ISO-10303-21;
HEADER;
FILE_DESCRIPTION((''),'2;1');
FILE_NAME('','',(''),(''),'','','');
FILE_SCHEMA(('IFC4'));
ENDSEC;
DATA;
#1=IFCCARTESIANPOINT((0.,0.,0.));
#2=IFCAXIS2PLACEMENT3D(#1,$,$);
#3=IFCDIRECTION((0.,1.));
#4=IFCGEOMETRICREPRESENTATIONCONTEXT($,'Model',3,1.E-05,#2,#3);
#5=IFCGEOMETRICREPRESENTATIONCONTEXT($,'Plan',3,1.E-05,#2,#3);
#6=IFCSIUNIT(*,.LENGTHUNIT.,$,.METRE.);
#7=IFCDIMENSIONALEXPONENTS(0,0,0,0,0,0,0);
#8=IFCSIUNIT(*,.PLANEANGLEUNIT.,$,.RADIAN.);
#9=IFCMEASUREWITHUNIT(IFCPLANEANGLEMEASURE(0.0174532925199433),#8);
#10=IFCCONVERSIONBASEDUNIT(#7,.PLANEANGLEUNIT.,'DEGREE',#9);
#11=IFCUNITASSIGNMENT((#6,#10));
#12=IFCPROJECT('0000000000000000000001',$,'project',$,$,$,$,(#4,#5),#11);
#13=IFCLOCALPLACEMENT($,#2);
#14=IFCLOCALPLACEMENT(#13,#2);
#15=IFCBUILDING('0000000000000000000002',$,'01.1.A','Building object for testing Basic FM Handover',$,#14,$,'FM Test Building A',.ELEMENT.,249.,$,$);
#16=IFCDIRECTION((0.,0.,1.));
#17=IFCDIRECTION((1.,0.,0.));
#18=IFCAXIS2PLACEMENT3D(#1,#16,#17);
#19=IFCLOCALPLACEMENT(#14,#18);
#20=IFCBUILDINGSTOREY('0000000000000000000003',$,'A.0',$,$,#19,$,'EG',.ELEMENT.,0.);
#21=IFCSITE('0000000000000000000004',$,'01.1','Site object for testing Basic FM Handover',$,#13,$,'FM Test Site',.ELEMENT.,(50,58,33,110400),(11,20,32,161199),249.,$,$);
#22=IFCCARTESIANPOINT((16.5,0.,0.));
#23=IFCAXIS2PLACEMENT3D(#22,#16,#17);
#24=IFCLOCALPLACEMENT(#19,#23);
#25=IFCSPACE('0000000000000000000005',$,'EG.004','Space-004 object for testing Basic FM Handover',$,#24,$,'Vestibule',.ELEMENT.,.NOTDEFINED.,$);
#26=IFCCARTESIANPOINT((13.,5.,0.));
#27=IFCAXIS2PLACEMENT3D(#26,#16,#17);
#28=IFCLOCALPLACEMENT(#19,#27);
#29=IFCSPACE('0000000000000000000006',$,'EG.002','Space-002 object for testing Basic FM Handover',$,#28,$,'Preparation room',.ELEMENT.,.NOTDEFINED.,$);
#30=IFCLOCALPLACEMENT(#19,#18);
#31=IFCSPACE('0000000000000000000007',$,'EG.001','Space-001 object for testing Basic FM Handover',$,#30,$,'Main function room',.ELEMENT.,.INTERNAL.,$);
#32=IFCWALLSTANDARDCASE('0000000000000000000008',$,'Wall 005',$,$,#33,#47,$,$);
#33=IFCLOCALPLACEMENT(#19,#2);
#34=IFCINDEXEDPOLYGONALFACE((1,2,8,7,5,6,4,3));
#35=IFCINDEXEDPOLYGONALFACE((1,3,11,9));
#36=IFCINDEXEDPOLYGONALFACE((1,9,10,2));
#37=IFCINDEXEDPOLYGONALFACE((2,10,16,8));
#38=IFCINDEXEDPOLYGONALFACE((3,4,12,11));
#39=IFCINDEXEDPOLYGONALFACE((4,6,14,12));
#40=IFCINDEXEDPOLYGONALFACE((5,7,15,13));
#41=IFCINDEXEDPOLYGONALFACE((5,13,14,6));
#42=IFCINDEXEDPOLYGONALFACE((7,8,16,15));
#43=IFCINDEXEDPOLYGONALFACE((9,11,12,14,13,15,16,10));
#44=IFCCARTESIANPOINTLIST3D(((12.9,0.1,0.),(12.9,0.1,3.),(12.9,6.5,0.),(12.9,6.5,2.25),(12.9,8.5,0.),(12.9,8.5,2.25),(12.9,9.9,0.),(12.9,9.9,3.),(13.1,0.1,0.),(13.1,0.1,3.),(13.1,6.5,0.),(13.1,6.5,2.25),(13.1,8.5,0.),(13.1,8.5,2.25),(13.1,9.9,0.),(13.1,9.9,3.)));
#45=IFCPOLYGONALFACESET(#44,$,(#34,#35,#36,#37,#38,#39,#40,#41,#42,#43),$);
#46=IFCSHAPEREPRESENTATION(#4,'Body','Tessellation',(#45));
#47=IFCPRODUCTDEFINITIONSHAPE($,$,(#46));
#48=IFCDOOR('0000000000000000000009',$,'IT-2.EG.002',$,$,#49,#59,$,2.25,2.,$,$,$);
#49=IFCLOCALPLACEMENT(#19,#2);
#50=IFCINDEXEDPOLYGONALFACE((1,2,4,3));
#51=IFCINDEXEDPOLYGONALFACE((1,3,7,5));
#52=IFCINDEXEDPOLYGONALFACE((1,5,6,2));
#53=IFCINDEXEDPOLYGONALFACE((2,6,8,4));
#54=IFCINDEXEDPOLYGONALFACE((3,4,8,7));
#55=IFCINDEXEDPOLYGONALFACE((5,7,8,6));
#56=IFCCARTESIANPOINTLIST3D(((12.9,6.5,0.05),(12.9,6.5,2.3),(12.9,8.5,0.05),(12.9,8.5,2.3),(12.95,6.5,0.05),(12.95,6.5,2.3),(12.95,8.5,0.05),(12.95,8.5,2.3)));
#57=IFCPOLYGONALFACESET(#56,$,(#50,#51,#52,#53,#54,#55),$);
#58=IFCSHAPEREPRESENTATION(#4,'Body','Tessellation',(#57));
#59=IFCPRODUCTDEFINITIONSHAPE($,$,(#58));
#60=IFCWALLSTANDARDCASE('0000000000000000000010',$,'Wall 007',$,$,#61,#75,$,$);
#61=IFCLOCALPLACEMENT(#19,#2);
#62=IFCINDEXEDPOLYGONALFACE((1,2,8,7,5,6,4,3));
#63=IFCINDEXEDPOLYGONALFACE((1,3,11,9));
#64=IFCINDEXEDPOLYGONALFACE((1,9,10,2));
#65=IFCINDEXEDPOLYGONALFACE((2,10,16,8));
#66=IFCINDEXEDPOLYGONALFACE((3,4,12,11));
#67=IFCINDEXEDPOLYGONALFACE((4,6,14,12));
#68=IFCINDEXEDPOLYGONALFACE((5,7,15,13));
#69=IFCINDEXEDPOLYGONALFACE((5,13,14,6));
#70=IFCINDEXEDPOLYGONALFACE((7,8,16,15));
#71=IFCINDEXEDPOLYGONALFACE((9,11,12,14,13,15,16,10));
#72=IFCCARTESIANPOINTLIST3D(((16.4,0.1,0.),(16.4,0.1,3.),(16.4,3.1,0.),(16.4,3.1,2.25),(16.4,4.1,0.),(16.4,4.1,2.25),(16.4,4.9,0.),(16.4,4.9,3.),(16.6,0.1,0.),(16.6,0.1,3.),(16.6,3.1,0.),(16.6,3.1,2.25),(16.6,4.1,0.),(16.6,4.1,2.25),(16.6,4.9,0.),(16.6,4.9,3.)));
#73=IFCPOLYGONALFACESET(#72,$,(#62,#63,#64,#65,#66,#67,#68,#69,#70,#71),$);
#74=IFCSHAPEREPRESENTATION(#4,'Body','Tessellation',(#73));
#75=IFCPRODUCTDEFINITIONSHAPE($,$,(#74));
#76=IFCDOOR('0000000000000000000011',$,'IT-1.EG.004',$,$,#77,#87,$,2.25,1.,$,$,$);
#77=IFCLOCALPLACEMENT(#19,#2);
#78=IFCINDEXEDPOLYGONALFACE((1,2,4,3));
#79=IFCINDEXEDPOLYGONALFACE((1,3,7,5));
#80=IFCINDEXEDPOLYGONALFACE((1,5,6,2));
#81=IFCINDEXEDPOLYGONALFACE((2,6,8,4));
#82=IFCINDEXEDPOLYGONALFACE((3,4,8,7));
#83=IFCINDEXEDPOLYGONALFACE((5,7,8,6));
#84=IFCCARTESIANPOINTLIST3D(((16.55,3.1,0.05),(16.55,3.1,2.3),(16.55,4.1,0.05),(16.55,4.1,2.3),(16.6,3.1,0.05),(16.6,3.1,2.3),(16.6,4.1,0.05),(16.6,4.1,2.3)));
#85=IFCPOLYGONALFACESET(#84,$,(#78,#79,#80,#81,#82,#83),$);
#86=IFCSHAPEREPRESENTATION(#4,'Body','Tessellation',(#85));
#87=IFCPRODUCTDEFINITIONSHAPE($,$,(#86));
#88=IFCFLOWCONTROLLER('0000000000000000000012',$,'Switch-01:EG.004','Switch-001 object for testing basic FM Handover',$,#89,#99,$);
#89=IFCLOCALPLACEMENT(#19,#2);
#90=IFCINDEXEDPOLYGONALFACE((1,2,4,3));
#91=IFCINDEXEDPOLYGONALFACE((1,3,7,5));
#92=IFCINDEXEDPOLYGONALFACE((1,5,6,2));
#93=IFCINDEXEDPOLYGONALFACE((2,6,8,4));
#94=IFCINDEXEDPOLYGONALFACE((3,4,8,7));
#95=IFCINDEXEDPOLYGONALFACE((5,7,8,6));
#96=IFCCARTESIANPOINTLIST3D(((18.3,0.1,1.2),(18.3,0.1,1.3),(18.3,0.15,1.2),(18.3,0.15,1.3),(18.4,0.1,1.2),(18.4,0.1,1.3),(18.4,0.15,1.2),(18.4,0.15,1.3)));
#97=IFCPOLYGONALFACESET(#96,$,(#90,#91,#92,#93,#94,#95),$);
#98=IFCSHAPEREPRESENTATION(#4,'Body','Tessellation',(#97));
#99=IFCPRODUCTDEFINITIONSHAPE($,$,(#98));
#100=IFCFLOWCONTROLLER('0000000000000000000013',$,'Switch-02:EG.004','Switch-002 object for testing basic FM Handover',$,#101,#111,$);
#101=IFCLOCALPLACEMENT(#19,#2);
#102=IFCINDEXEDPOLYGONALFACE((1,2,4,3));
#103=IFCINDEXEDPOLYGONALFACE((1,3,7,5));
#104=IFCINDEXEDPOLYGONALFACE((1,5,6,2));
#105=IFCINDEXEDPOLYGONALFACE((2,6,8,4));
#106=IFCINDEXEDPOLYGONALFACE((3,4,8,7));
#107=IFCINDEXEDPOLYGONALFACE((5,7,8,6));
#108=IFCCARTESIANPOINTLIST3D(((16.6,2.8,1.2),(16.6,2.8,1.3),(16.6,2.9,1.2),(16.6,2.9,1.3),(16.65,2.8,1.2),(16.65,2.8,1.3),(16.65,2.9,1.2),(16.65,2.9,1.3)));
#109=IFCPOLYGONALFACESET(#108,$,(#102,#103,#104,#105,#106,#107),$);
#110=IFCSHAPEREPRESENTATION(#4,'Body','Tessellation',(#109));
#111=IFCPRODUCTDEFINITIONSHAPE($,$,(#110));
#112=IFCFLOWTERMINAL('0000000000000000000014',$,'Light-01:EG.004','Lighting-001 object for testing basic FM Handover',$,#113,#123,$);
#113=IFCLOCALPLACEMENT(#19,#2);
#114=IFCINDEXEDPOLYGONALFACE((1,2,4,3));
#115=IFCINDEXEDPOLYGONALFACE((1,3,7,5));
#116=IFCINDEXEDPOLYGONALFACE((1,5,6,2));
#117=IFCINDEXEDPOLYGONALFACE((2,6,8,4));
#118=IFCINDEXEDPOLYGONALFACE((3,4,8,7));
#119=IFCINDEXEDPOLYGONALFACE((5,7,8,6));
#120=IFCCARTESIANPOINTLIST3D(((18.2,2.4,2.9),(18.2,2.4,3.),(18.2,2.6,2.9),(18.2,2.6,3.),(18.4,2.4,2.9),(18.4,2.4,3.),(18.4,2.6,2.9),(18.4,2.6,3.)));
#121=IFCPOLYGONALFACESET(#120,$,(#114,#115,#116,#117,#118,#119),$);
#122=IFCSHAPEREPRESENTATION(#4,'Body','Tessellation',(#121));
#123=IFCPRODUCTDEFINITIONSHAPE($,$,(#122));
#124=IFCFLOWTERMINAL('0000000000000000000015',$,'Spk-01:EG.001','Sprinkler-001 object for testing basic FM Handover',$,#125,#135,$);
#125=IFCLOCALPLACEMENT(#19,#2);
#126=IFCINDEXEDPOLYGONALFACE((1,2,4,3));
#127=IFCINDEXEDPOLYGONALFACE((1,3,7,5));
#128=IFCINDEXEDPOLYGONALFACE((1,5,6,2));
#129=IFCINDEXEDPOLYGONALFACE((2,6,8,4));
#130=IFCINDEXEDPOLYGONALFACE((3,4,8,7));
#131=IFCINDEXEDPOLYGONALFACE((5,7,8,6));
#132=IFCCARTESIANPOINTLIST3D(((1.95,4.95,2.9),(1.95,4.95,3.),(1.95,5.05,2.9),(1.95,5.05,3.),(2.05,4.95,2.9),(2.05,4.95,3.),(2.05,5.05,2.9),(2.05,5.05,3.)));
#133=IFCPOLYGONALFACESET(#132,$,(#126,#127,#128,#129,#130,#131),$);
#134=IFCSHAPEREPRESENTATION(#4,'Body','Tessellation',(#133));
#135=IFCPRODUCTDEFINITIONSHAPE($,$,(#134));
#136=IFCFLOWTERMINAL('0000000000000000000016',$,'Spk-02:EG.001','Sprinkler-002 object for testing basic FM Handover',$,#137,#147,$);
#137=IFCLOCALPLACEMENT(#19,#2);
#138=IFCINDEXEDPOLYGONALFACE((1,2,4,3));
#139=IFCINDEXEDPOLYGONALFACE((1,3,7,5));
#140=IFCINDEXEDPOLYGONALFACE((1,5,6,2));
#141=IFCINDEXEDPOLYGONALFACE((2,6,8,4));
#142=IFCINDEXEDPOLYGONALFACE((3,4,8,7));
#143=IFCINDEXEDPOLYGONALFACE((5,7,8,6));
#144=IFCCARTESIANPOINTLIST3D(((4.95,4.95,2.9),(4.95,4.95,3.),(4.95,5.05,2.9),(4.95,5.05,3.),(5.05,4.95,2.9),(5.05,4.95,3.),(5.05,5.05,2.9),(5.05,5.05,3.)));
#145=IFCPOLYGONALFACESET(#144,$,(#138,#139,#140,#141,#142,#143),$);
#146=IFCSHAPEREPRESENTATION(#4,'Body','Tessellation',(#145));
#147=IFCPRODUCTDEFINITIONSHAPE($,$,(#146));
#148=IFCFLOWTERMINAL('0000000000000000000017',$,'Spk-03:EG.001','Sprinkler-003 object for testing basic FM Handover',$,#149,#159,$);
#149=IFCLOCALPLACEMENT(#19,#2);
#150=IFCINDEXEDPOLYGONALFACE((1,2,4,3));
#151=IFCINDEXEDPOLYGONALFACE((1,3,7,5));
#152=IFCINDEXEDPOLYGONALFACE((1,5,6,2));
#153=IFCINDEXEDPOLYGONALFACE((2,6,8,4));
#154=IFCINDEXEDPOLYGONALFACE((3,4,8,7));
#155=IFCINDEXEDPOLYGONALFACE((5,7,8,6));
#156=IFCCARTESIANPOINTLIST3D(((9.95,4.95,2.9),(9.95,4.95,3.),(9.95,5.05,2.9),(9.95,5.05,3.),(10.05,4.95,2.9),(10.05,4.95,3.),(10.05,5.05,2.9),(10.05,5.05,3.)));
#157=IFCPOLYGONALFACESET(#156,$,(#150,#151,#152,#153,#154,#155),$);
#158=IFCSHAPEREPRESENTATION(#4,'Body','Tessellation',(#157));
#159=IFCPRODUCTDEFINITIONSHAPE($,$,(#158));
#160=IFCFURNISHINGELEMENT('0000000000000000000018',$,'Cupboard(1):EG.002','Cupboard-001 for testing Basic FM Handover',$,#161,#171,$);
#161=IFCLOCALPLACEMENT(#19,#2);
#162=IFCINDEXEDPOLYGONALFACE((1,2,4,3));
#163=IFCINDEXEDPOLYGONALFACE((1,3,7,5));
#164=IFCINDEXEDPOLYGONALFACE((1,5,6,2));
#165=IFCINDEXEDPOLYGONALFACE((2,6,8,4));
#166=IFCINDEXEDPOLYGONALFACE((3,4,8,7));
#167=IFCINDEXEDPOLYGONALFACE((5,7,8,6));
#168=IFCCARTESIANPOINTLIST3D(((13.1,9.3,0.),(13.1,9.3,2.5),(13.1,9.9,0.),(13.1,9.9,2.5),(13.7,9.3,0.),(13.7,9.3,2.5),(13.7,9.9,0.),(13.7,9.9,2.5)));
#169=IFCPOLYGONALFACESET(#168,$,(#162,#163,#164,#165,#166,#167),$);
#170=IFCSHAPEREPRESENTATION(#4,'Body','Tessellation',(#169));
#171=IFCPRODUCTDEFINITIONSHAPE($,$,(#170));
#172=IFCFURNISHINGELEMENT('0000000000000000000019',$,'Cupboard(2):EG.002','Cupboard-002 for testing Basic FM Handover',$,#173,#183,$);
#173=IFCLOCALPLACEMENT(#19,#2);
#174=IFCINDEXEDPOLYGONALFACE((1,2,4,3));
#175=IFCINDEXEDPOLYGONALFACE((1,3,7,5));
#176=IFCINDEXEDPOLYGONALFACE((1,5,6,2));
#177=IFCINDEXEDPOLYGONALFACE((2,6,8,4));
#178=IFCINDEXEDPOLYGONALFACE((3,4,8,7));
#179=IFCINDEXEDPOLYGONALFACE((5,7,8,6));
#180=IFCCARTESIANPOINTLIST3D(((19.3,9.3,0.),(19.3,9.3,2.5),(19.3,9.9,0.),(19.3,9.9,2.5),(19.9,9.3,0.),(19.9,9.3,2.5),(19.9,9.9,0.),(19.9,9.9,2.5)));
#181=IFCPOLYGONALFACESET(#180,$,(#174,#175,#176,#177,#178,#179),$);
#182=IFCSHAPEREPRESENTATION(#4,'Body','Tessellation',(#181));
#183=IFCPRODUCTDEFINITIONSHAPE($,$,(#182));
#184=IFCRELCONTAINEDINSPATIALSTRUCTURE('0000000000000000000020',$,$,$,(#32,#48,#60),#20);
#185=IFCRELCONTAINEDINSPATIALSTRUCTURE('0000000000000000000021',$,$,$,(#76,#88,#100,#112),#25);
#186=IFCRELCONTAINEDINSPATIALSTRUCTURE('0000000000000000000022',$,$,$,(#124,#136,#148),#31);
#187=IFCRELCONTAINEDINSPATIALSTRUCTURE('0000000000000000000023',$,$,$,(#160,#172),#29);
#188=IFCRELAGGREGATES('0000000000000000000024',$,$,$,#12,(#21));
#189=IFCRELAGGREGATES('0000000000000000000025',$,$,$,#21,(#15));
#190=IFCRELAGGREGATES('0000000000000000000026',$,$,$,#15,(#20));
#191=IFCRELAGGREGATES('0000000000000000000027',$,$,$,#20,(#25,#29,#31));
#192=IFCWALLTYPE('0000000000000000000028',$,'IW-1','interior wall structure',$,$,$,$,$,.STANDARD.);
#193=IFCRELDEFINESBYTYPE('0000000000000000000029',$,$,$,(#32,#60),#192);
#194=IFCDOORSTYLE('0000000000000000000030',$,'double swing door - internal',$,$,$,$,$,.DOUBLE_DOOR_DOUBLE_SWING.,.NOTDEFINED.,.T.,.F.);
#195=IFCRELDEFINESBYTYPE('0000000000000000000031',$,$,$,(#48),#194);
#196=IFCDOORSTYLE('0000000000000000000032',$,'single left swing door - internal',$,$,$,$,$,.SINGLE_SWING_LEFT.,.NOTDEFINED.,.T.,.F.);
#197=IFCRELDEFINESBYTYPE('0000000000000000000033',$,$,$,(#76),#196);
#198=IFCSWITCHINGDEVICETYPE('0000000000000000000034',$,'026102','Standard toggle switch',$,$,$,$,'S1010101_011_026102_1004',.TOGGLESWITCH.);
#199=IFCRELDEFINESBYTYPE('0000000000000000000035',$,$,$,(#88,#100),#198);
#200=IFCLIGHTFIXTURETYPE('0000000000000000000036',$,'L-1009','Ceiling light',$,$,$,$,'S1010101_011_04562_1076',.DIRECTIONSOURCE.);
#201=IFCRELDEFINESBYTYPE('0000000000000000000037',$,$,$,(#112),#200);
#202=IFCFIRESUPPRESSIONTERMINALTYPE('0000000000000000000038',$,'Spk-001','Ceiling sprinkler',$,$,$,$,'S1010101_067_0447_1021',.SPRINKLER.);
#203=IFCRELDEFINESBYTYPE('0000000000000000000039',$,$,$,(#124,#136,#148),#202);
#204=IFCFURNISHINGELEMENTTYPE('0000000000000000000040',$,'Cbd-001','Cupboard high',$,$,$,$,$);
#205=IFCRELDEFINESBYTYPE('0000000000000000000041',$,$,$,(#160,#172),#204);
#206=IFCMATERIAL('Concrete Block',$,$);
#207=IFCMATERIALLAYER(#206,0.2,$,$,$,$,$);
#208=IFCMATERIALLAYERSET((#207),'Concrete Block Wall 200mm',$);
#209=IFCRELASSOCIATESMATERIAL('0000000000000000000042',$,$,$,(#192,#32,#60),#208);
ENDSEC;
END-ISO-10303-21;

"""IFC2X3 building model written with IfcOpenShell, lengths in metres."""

from ifc_helpers import new_model, entity, si_unit, converted_unit, direction, frame, frame_2d, origin, origin_with_axes, place, context, project, spatial, polyline, rectangle, outline, extrude, source, transform, mapped, material, layer, layer_set, layer_usage, type_object, type_shapes, element, fill, save


model = new_model("IFC2X3")

# Units and contexts
model_context = context("Model", 3, precision=1e-05, world=origin(), true_north=direction((0.0, 1.0)))
plan_context = context("Plan", 3, precision=1e-05, world=origin(), true_north=direction((0.0, 1.0)))
ifc_project = project(units=[si_unit("LENGTHUNIT", "METRE"), converted_unit("PLANEANGLEUNIT", "DEGREE", entity("IfcPlaneAngleMeasure", 0.0174532925199433), si_unit("PLANEANGLEUNIT", "RADIAN"), dimensions=[0, 0, 0, 0, 0, 0, 0])], contexts=[model_context, plan_context])

# Site, building, storey
site_placement = place(None, origin())
site = spatial("IfcSite", under=ifc_project, at=site_placement, Name="01.1", Description="Site object for testing Basic FM Handover", LongName="FM Test Site", CompositionType="ELEMENT", RefLatitude=(50, 58, 33, 110400), RefLongitude=(11, 20, 32, 161199), RefElevation=249.0)
building_placement = place(site_placement, origin())
building = spatial("IfcBuilding", under=site, at=building_placement, Name="01.1.A", Description="Building object for testing Basic FM Handover", LongName="FM Test Building A", CompositionType="ELEMENT", ElevationOfRefHeight=249.0)
storey_placement = place(building_placement, origin_with_axes())
storey = spatial("IfcBuildingStorey", under=building, at=storey_placement, Name="A.0", LongName="EG", CompositionType="ELEMENT", Elevation=0.0)

# Shared definitions
space_1_placement = place(storey_placement, frame((16.5, 0.0, 0.0), z_axis=(0.0, 0.0, 1.0), x_axis=(1.0, 0.0, 0.0)))
space_1 = spatial("IfcSpace", under=storey, at=space_1_placement, Name="EG.004", Description="Space-004 object for testing Basic FM Handover", LongName="Vestibule", CompositionType="ELEMENT", InteriorOrExteriorSpace="NOTDEFINED")

# Wall, opening, door
ifc_material_1 = material(Name="Concrete Block")
ifc_layer_1 = layer(ifc_material_1, 0.2)
ifc_layer_set_1 = layer_set([ifc_layer_1], Name="Concrete Block Wall 200mm")
ifc_layer_usage_1 = layer_usage(ifc_layer_set_1, "AXIS2", "POSITIVE", -0.1)
wall_type_1 = type_object("IfcWallType", Name="IW-1", Description="interior wall structure", PredefinedType="STANDARD", material=ifc_layer_set_1)
wall_1_placement = place(storey_placement, frame((13.0, 0.0, 0.0), z_axis=(0.0, 0.0, 1.0), x_axis=(0.0, 1.0, 0.0)))
wall_1 = element("IfcWallStandardCase", 1, at=wall_1_placement, inside=storey, type_object=wall_type_1, material=ifc_layer_usage_1, Name="Wall 005", context=model_context, shape_type="SweptSolid", body=[
    extrude(outline(polyline([(0.1, -0.1), (9.9, -0.1), (9.9, 0.1), (0.1, 0.1), (0.1, -0.1)])), origin(), (0.0, 0.0, 1.0), 3.0),
])
opening_1_placement = place(wall_1_placement, frame((6.5, -0.1, 0.0), z_axis=(0.0, 0.0, 1.0), x_axis=(1.0, 0.0, 0.0)))
opening_1 = element("IfcOpeningElement", 2, at=opening_1_placement, cuts=wall_1, context=model_context, shape_type="SweptSolid", body=[
    extrude(rectangle(XDim=2.25, YDim=2.0, at=frame_2d((1.125, 1.0))), frame((0.0, 0.0, 0.0), z_axis=(0.0, 1.0, 0.0), x_axis=(0.0, 0.0, 1.0)), (0.0, 0.0, 1.0), 0.2),
])
door_style_1 = type_object("IfcDoorStyle", Name="double swing door - internal", ConstructionType="NOTDEFINED", OperationType="DOUBLE_DOOR_DOUBLE_SWING", ParameterTakesPrecedence=True, Sizeable=False)
door_1_placement = place(opening_1_placement, origin_with_axes())
door_1 = element("IfcDoor", 3, at=door_1_placement, inside=storey, type_object=door_style_1, Name="IT-2.EG.002", OverallHeight=2.25, OverallWidth=2.0, context=model_context, shape_type="SweptSolid", body=[
    extrude(rectangle(XDim=2.25, YDim=2.0, at=frame_2d((1.075, 1.0))), frame((0.0, 0.15, 0.1), z_axis=(0.0, 1.0, 0.0), x_axis=(0.0, 0.0, 1.0)), (0.0, 0.0, 1.0), 0.05),
])
fill(opening_1, door_1)

# Wall, opening, door
ifc_layer_usage_2 = layer_usage(ifc_layer_set_1, "AXIS2", "POSITIVE", -0.1)
wall_2_placement = place(storey_placement, frame((16.5, 0.0, 0.0), z_axis=(0.0, 0.0, 1.0), x_axis=(0.0, 1.0, 0.0)))
wall_2 = element("IfcWallStandardCase", 4, at=wall_2_placement, inside=storey, type_object=wall_type_1, material=ifc_layer_usage_2, Name="Wall 007", context=model_context, shape_type="SweptSolid", body=[
    extrude(rectangle(XDim=4.8, YDim=0.2, at=frame_2d((2.5, 0.0))), origin(), (0.0, 0.0, 1.0), 3.0),
])
opening_2_placement = place(wall_2_placement, frame((4.1, 0.1, 0.0), z_axis=(0.0, 0.0, 1.0), x_axis=(-1.0, 0.0, 0.0)))
opening_2 = element("IfcOpeningElement", 5, at=opening_2_placement, cuts=wall_2, context=model_context, shape_type="SweptSolid", body=[
    extrude(rectangle(XDim=2.25, YDim=1.0, at=frame_2d((1.125, 0.5))), frame((0.0, 0.0, 0.0), z_axis=(0.0, 1.0, 0.0), x_axis=(0.0, 0.0, 1.0)), (0.0, 0.0, 1.0), 0.2),
])
door_style_2 = type_object("IfcDoorStyle", Name="single left swing door - internal", ConstructionType="NOTDEFINED", OperationType="SINGLE_SWING_LEFT", ParameterTakesPrecedence=True, Sizeable=False)
door_2_placement = place(opening_2_placement, origin_with_axes())
door_2 = element("IfcDoor", 6, at=door_2_placement, inside=space_1, type_object=door_style_2, Name="IT-1.EG.004", OverallHeight=2.25, OverallWidth=1.0, context=model_context, shape_type="SweptSolid", body=[
    extrude(rectangle(XDim=2.25, YDim=1.0, at=frame_2d((1.075, 0.5))), frame((0.0, 0.15, 0.1), z_axis=(0.0, 1.0, 0.0), x_axis=(0.0, 0.0, 1.0)), (0.0, 0.0, 1.0), 0.05),
])
fill(opening_2, door_2)

# Shared definitions
space_2_placement = place(storey_placement, frame((13.0, 5.0, 0.0), z_axis=(0.0, 0.0, 1.0), x_axis=(1.0, 0.0, 0.0)))
space_2 = spatial("IfcSpace", under=storey, at=space_2_placement, Name="EG.002", Description="Space-002 object for testing Basic FM Handover", LongName="Preparation room", CompositionType="ELEMENT", InteriorOrExteriorSpace="NOTDEFINED")

# Flow controllers
switching_device_type = type_object("IfcSwitchingDeviceType", Name="026102", Description="Standard toggle switch", ElementType="S1010101_011_026102_1004", PredefinedType="TOGGLESWITCH")
shared_shape_1 = source(origin_with_axes(), model_context, "Body", "SweptSolid", [
    extrude(outline(polyline([(0.0, 0.0), (0.1, 0.0), (0.1, 0.05), (0.0, 0.05), (0.0, 0.0)])), origin(), (0.0, 0.0, 1.0), 0.1),
])
type_shapes(switching_device_type, [shared_shape_1])
for number, where, z_axis, x_axis, name, description in (
    (7, (18.3, 0.1, 1.2), (0.0, 0.0, 1.0), (1.0, 0.0, 0.0), "Switch-01:EG.004", "Switch-001 object for testing basic FM Handover"),
    (8, (16.65, 2.8, 1.2), (0.0, 0.0, 1.0), (0.0, 1.0, 0.0), "Switch-02:EG.004", "Switch-002 object for testing basic FM Handover"),
):
    element("IfcFlowController", number, at=place(storey_placement, frame(where, z_axis=z_axis, x_axis=x_axis)), inside=space_1, type_object=switching_device_type, Name=name, Description=description, context=model_context, shape_type="MappedRepresentation", body=[
        mapped(shared_shape_1, transform((0.0, 0.0, 0.0))),
    ])

# Flow terminal
light_fixture_type = type_object("IfcLightFixtureType", Name="L-1009", Description="Ceiling light", ElementType="S1010101_011_04562_1076", PredefinedType="DIRECTIONSOURCE")
shared_shape_2 = source(origin_with_axes(), model_context, "Body", "SweptSolid", [
    extrude(outline(polyline([(-0.1, -0.1), (0.1, -0.1), (0.1, 0.1), (-0.1, 0.1), (-0.1, -0.1)])), origin(), (0.0, 0.0, 1.0), 0.1),
])
type_shapes(light_fixture_type, [shared_shape_2])
flow_terminal_placement = place(storey_placement, frame((18.3, 2.5, 2.9), z_axis=(0.0, 0.0, 1.0), x_axis=(1.0, 0.0, 0.0)))
element("IfcFlowTerminal", 9, at=flow_terminal_placement, inside=space_1, type_object=light_fixture_type, Name="Light-01:EG.004", Description="Lighting-001 object for testing basic FM Handover", context=model_context, shape_type="MappedRepresentation", body=[
    mapped(shared_shape_2, transform((0.0, 0.0, 0.0))),
])

# Shared definitions
space_3_placement = place(storey_placement, origin_with_axes())
space_3 = spatial("IfcSpace", under=storey, at=space_3_placement, Name="EG.001", Description="Space-001 object for testing Basic FM Handover", LongName="Main function room", CompositionType="ELEMENT", InteriorOrExteriorSpace="INTERNAL")

# Flow terminals
fire_suppression_terminal_type = type_object("IfcFireSuppressionTerminalType", Name="Spk-001", Description="Ceiling sprinkler", ElementType="S1010101_067_0447_1021", PredefinedType="SPRINKLER")
shared_shape_3 = source(origin_with_axes(), model_context, "Body", "SweptSolid", [
    extrude(outline(polyline([(-0.05, -0.05), (0.05, -0.05), (0.05, 0.05), (-0.05, 0.05), (-0.05, -0.05)])), origin(), (0.0, 0.0, 1.0), 0.1),
])
type_shapes(fire_suppression_terminal_type, [shared_shape_3])
for number, where, z_axis, x_axis, name, description in (
    (10, (2.0, 5.0, 2.9), (0.0, 0.0, 1.0), (1.0, 0.0, 0.0), "Spk-01:EG.001", "Sprinkler-001 object for testing basic FM Handover"),
    (11, (5.0, 5.0, 2.9), (0.0, 0.0, 1.0), (1.0, 0.0, 0.0), "Spk-02:EG.001", "Sprinkler-002 object for testing basic FM Handover"),
    (12, (10.0, 5.0, 2.9), (0.0, 0.0, 1.0), (1.0, 0.0, 0.0), "Spk-03:EG.001", "Sprinkler-003 object for testing basic FM Handover"),
):
    element("IfcFlowTerminal", number, at=place(storey_placement, frame(where, z_axis=z_axis, x_axis=x_axis)), inside=space_3, type_object=fire_suppression_terminal_type, Name=name, Description=description, context=model_context, shape_type="MappedRepresentation", body=[
        mapped(shared_shape_3, transform((0.0, 0.0, 0.0))),
    ])

# Furnishing elements
furnishing_element_type_1 = type_object("IfcFurnishingElementType", Name="Cbd-001", Description="Cupboard high")
shared_shape_4 = source(origin_with_axes(), model_context, "Body", "SweptSolid", [
    extrude(rectangle(XDim=0.6, YDim=0.6, at=frame_2d((0.3, 0.3))), origin(), (0.0, 0.0, 1.0), 2.5),
])
type_shapes(furnishing_element_type_1, [shared_shape_4])
for number, where, z_axis, x_axis, name, description in (
    (13, (13.1, 9.3, 0.0), (0.0, 0.0, 1.0), (1.0, 0.0, 0.0), "Cupboard(1):EG.002", "Cupboard-001 for testing Basic FM Handover"),
    (14, (19.3, 9.3, 0.0), (0.0, 0.0, 1.0), (1.0, 0.0, 0.0), "Cupboard(2):EG.002", "Cupboard-002 for testing Basic FM Handover"),
):
    element("IfcFurnishingElement", number, at=place(storey_placement, frame(where, z_axis=z_axis, x_axis=x_axis)), inside=space_2, type_object=furnishing_element_type_1, Name=name, Description=description, context=model_context, shape_type="MappedRepresentation", body=[
        mapped(shared_shape_4, transform((0.0, 0.0, 0.0))),
    ])

save(model, "model.ifc")
